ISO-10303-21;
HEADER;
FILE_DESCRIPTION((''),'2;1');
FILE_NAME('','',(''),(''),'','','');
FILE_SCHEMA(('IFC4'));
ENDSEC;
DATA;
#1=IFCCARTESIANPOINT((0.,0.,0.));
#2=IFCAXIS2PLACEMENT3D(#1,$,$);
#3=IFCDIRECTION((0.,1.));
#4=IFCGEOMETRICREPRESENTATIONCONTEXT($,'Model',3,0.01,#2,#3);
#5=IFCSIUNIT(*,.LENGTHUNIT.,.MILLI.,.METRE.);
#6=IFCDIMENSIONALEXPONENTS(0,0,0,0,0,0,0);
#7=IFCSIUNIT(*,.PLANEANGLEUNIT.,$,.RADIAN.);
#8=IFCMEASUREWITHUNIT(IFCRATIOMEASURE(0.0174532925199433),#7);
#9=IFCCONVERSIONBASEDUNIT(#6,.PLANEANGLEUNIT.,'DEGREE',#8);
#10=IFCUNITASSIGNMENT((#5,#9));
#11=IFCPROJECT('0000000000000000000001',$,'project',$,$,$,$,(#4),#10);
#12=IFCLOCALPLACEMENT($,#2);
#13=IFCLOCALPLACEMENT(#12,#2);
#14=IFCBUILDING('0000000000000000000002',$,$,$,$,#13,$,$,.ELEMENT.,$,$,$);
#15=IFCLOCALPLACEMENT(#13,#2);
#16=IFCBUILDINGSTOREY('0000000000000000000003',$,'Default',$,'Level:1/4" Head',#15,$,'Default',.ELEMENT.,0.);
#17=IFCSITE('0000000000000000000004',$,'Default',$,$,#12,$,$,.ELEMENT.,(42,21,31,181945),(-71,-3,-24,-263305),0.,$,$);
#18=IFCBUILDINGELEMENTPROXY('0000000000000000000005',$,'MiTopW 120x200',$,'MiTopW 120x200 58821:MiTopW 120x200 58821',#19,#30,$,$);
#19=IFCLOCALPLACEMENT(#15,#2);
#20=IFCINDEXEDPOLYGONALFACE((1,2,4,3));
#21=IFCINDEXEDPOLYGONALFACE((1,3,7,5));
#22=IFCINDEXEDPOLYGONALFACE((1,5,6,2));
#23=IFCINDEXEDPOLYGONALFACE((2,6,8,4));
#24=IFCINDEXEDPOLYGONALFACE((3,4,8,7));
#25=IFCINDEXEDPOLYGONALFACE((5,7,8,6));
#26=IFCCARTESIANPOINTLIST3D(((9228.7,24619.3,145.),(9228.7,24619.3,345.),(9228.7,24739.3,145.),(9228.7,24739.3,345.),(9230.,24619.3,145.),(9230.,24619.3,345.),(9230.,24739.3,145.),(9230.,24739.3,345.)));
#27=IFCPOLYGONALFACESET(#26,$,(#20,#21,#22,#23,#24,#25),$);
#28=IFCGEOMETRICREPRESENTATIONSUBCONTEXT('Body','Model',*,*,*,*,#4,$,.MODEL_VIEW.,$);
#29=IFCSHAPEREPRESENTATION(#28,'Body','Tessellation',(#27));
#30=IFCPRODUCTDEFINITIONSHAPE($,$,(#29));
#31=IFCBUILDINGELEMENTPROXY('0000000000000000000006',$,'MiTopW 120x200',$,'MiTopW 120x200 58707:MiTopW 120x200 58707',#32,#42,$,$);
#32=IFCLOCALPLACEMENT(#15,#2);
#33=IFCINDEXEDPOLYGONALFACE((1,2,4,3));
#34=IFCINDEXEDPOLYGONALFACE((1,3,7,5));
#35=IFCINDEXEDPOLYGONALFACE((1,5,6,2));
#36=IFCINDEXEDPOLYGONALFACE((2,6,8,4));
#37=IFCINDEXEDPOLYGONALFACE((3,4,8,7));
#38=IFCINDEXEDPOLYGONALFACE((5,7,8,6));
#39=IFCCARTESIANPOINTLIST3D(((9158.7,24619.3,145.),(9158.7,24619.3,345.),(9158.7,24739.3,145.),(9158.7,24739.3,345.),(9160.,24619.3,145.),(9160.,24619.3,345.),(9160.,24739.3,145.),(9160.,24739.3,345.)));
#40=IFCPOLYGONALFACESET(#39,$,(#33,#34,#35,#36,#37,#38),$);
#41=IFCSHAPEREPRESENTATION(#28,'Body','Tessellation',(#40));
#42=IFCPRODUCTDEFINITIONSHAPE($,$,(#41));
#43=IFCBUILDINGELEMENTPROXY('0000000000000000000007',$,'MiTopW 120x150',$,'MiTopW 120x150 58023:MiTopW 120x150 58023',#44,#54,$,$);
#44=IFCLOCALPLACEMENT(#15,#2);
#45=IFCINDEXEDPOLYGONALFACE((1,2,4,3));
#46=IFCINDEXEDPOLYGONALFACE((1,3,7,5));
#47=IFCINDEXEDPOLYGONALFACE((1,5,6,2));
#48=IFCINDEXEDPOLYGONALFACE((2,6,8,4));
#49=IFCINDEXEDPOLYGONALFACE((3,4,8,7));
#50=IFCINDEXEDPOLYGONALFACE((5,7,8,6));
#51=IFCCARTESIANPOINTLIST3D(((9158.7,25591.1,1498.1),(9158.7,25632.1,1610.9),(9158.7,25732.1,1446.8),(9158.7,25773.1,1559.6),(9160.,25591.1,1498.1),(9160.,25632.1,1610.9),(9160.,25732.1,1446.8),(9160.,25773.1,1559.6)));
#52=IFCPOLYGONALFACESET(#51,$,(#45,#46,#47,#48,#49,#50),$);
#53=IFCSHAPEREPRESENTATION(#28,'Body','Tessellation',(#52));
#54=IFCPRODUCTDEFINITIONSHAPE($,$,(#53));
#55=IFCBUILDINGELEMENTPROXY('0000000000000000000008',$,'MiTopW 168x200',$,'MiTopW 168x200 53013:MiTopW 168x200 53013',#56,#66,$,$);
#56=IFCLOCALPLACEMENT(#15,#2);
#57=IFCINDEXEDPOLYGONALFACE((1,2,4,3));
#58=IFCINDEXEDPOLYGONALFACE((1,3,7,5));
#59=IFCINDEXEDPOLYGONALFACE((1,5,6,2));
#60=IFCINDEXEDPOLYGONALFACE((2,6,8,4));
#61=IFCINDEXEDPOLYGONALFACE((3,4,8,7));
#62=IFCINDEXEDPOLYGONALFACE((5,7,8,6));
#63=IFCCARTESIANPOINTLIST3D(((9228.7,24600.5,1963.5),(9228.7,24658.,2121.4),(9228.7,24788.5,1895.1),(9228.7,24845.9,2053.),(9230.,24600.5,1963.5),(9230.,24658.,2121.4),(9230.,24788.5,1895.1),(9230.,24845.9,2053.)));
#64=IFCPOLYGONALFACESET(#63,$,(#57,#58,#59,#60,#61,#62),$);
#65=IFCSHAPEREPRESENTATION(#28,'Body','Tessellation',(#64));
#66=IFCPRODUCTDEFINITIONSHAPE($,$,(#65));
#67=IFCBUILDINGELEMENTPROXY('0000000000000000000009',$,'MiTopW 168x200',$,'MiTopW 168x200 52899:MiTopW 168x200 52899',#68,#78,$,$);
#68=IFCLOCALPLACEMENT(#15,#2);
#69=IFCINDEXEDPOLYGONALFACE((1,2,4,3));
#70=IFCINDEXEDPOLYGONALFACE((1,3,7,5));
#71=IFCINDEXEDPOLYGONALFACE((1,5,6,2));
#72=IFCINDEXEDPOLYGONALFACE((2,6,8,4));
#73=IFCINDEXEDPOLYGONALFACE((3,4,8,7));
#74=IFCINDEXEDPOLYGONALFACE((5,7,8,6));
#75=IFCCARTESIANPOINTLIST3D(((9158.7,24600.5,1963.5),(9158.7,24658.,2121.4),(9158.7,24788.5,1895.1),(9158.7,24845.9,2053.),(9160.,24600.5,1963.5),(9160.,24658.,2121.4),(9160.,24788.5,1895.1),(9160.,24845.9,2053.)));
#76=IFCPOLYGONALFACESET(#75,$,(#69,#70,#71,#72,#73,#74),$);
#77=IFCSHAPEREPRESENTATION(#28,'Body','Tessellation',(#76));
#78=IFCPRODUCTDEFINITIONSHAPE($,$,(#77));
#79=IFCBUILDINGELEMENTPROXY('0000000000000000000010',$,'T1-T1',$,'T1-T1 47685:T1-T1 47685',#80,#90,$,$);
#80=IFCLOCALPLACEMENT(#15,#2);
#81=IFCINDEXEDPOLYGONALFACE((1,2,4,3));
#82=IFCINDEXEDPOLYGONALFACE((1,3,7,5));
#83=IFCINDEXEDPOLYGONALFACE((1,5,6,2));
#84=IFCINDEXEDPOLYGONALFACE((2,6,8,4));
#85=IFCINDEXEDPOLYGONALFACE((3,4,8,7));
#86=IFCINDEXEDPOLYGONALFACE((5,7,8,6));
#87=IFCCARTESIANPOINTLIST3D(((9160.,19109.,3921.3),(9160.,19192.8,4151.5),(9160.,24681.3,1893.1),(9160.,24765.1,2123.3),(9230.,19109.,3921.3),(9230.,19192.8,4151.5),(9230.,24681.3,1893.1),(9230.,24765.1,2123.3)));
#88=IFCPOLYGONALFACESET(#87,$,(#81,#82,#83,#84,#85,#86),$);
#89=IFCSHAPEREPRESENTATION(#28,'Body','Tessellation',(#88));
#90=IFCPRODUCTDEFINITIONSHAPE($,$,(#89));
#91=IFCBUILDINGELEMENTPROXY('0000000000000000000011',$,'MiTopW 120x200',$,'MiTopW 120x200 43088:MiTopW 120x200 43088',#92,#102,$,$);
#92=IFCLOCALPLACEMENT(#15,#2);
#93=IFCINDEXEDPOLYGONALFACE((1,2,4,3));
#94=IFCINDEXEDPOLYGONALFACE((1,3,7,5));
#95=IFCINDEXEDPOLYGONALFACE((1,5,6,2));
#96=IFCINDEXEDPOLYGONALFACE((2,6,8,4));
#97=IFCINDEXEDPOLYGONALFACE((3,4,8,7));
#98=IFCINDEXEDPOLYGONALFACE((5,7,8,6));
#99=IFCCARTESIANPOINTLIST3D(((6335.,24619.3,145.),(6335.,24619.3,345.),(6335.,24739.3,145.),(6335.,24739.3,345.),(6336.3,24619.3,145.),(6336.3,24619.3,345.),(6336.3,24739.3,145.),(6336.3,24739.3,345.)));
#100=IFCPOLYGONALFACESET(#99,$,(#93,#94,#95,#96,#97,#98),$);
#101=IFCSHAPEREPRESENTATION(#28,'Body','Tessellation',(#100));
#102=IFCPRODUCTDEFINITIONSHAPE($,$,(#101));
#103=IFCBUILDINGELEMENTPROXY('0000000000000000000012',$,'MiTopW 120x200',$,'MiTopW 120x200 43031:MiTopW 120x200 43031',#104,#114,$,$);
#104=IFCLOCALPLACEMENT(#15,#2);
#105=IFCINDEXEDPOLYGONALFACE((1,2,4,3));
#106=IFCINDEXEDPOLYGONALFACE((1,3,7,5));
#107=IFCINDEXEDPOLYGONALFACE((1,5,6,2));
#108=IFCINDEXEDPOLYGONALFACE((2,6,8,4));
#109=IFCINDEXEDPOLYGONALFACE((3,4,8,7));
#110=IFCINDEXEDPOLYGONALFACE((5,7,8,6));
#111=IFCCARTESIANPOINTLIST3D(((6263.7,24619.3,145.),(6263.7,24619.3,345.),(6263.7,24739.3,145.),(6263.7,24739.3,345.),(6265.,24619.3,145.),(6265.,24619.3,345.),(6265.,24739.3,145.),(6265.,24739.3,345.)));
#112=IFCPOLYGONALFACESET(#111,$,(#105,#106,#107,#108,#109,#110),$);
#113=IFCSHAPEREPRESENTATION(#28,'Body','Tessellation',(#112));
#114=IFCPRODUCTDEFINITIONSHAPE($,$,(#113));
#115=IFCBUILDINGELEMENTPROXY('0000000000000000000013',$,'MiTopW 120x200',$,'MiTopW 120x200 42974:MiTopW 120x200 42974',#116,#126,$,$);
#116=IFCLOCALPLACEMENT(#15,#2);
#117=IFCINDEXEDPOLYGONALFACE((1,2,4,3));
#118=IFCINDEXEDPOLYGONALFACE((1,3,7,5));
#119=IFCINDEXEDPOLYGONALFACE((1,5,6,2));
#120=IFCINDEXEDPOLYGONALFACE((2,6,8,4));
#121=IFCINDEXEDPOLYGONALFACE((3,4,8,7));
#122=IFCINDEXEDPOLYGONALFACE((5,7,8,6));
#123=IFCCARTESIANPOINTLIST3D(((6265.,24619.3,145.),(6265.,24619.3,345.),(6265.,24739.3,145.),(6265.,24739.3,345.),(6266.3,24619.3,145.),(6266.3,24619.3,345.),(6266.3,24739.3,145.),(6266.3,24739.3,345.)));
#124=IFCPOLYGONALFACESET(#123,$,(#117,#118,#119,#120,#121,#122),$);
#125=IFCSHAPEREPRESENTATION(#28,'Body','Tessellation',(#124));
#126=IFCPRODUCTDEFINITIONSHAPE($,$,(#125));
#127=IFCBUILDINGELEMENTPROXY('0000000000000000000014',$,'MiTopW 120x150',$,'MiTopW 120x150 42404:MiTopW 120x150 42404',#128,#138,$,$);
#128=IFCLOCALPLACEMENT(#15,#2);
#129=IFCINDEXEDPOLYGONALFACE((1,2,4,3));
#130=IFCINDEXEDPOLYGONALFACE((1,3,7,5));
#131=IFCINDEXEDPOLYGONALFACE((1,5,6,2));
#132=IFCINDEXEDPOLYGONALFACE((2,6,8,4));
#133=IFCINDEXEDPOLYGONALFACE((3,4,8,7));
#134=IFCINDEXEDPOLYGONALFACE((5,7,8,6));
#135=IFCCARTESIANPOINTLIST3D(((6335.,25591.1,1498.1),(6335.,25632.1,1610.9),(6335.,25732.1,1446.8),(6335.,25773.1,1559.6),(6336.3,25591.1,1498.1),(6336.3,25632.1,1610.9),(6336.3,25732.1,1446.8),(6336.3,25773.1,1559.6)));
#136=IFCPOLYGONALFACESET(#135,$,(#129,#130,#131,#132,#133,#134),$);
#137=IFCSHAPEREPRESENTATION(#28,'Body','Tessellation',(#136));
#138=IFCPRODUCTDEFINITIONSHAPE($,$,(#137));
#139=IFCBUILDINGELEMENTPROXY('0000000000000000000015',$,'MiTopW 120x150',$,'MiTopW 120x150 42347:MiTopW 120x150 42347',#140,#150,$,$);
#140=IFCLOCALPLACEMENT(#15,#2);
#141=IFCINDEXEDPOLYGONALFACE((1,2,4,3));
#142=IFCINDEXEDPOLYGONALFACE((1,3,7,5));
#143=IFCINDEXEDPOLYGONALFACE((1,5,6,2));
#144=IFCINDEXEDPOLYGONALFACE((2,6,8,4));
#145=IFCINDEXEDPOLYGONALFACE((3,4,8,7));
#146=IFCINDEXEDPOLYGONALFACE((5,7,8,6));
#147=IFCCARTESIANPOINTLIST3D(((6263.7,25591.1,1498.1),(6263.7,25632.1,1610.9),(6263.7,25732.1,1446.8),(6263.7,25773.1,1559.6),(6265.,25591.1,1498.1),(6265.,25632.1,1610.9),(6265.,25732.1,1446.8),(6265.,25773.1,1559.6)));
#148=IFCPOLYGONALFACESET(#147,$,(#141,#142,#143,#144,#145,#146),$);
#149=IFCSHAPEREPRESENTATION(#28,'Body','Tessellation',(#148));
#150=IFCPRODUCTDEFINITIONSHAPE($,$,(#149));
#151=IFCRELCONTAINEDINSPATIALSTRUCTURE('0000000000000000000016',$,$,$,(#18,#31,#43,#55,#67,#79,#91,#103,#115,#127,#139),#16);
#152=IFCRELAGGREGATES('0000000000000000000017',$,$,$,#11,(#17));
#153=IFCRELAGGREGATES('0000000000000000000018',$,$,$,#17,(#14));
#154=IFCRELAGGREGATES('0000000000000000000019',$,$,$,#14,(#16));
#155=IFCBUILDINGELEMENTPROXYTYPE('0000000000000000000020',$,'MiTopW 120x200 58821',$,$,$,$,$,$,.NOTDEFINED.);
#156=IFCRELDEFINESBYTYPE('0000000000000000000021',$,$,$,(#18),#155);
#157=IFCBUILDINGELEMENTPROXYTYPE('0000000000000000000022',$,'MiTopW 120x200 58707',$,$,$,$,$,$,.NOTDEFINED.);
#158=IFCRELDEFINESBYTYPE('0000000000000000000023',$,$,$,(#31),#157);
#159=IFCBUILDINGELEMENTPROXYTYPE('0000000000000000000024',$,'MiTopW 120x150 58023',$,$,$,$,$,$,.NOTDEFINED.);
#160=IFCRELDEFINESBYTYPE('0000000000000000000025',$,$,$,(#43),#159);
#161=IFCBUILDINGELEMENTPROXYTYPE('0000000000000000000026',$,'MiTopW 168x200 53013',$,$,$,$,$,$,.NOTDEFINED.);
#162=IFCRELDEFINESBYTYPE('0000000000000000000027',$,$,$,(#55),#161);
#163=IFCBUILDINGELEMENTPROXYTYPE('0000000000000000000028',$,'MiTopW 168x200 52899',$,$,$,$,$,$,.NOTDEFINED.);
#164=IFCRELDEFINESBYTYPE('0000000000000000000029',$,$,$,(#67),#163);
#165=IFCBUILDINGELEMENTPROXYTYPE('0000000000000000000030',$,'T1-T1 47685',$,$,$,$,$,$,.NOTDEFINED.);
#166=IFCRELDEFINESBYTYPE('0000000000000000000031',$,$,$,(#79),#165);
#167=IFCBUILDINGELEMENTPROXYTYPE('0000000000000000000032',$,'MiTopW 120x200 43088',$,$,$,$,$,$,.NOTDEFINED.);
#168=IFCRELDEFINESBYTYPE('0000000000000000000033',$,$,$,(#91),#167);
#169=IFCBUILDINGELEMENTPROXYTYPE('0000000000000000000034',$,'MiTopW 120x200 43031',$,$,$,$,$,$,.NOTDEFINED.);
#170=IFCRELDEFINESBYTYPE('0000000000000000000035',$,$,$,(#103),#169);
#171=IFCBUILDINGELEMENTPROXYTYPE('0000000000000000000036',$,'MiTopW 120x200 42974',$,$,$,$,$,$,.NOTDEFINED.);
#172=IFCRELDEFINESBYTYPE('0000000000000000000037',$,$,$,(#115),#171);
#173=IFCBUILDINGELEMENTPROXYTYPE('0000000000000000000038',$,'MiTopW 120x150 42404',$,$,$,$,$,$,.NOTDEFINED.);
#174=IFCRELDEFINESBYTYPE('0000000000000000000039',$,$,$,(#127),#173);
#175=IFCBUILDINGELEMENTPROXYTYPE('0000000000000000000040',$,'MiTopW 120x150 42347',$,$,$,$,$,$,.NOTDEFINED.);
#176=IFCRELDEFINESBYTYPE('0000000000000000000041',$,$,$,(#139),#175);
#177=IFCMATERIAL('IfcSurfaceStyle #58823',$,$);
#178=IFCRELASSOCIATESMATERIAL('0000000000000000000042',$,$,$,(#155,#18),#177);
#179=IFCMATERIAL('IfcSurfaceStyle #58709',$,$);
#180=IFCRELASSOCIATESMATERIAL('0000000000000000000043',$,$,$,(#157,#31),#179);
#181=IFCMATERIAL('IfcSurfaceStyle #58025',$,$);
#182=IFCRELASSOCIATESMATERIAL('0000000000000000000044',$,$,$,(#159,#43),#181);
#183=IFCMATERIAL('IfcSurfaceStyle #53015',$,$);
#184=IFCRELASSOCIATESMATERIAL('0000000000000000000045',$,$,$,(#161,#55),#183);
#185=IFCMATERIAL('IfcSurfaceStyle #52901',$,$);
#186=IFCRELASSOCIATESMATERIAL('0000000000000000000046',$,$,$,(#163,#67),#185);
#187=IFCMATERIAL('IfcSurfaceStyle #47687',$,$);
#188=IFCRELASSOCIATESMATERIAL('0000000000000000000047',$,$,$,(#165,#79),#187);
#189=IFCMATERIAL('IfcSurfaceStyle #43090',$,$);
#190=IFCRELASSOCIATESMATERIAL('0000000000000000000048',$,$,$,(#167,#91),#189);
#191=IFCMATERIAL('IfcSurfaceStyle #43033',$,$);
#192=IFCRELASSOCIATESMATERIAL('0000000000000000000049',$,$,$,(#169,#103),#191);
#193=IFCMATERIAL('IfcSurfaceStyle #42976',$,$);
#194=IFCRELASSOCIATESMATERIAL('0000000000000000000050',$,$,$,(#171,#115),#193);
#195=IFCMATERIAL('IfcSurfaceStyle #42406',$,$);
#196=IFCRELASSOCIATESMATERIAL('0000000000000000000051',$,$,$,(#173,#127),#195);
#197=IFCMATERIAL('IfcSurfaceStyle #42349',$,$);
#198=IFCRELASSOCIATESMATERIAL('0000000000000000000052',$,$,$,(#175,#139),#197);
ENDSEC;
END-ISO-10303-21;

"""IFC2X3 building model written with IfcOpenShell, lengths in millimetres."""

from ifc_helpers import new_model, entity, si_unit, converted_unit, direction, frame, origin, origin_2d_with_axis, place, context, subcontext, project, spatial, polyline, rectangle, outline, extrude, source, transform, mapped, material, type_object, type_shapes, element, save


model = new_model("IFC2X3")

# Units and contexts
model_context = context("Model", 3, precision=0.01, world=origin(), true_north=direction((0.0, 1.0)))
body_context = subcontext(model_context, "Body", "Model", "MODEL_VIEW")
ifc_project = project(units=[si_unit("LENGTHUNIT", "METRE", prefix="MILLI"), converted_unit("PLANEANGLEUNIT", "DEGREE", entity("IfcRatioMeasure", 0.0174532925199433), si_unit("PLANEANGLEUNIT", "RADIAN"), dimensions=[0, 0, 0, 0, 0, 0, 0])], contexts=[model_context])

# Site, building, storey
site_placement = place(None, origin())
site = spatial("IfcSite", under=ifc_project, at=site_placement, Name="Default", CompositionType="ELEMENT", RefLatitude=(42, 21, 31, 181945), RefLongitude=(-71, -3, -24, -263305), RefElevation=0.0)
building_placement = place(site_placement, origin())
building = spatial("IfcBuilding", under=site, at=building_placement, CompositionType="ELEMENT")
storey_placement = place(building_placement, origin())
storey = spatial("IfcBuildingStorey", under=building, at=storey_placement, Name="Default", ObjectType="Level:1/4\" Head", LongName="Default", CompositionType="ELEMENT", Elevation=0.0)

# Building element proxies
ifc_material_1 = material(Name="IfcSurfaceStyle #58823")
building_element_proxy_type_1 = type_object("IfcBuildingElementProxyType", Name="MiTopW 120x200 58821", PredefinedType="NOTDEFINED", material=ifc_material_1)
shared_shape_1 = source(origin(), body_context, "Body", "SweptSolid", [
    extrude(rectangle(XDim=200.0, YDim=120.0, at=origin_2d_with_axis()), frame((100.0, 60.0, 0.0), z_axis=(0.0, 0.0, 1.0), x_axis=(-1.0, 0.0, 0.0)), (0.0, 0.0, 1.0), 1.3),
])
type_shapes(building_element_proxy_type_1, [shared_shape_1])
proxy_1_placement = place(building_placement, frame((9230.0, 24619.3, 145.0), z_axis=(-1.0, 0.0, 0.0), x_axis=(0.0, 0.0, 1.0)))
element("IfcBuildingElementProxy", 1, at=proxy_1_placement, inside=storey, type_object=building_element_proxy_type_1, material=ifc_material_1, Name="MiTopW 120x200", ObjectType="MiTopW 120x200 58821:MiTopW 120x200 58821", context=body_context, shape_type="MappedRepresentation", body=[
    mapped(shared_shape_1, transform((0.0, 0.0, 0.0), scale=1.0)),
])
ifc_material_2 = material(Name="IfcSurfaceStyle #58709")
building_element_proxy_type_2 = type_object("IfcBuildingElementProxyType", Name="MiTopW 120x200 58707", PredefinedType="NOTDEFINED", material=ifc_material_2)
shared_shape_2 = source(origin(), body_context, "Body", "SweptSolid", [
    extrude(rectangle(XDim=200.0, YDim=120.0, at=origin_2d_with_axis()), frame((100.0, 60.0, 0.0), z_axis=(0.0, 0.0, 1.0), x_axis=(-1.0, 0.0, 0.0)), (0.0, 0.0, 1.0), 1.3),
])
type_shapes(building_element_proxy_type_2, [shared_shape_2])
proxy_2_placement = place(building_placement, frame((9160.0, 24619.3, 145.0), z_axis=(-1.0, 0.0, 0.0), x_axis=(0.0, 0.0, 1.0)))
element("IfcBuildingElementProxy", 2, at=proxy_2_placement, inside=storey, type_object=building_element_proxy_type_2, material=ifc_material_2, Name="MiTopW 120x200", ObjectType="MiTopW 120x200 58707:MiTopW 120x200 58707", context=body_context, shape_type="MappedRepresentation", body=[
    mapped(shared_shape_2, transform((0.0, 0.0, 0.0), scale=1.0)),
])
ifc_material_3 = material(Name="IfcSurfaceStyle #58025")
building_element_proxy_type_3 = type_object("IfcBuildingElementProxyType", Name="MiTopW 120x150 58023", PredefinedType="NOTDEFINED", material=ifc_material_3)
shared_shape_3 = source(origin(), body_context, "Body", "SweptSolid", [
    extrude(outline(polyline([(-75.0, -60.0), (75.0, -60.0), (75.0, 60.0), (-75.0, 60.0), (-75.0, -60.0)])), frame((75.0, 60.0, 0.0), z_axis=(0.0, 0.0, 1.0), x_axis=(-1.0, 0.0, 0.0)), (0.0, 0.0, 1.0), 1.3),
])
type_shapes(building_element_proxy_type_3, [shared_shape_3])
proxy_3_placement = place(building_placement, frame((9160.0, 25732.1, 1446.8), z_axis=(-1.0, 0.0, 0.0), x_axis=(0.0, -0.939693, 0.34202)))
element("IfcBuildingElementProxy", 3, at=proxy_3_placement, inside=storey, type_object=building_element_proxy_type_3, material=ifc_material_3, Name="MiTopW 120x150", ObjectType="MiTopW 120x150 58023:MiTopW 120x150 58023", context=body_context, shape_type="MappedRepresentation", body=[
    mapped(shared_shape_3, transform((0.0, 0.0, 0.0), scale=1.0)),
])
ifc_material_4 = material(Name="IfcSurfaceStyle #53015")
building_element_proxy_type_4 = type_object("IfcBuildingElementProxyType", Name="MiTopW 168x200 53013", PredefinedType="NOTDEFINED", material=ifc_material_4)
shared_shape_4 = source(origin(), body_context, "Body", "SweptSolid", [
    extrude(outline(polyline([(-100.0, -84.0), (100.0, -84.0), (100.0, 84.0), (-100.0, 84.0), (-100.0, -84.0)])), frame((100.0, 84.0, 0.0), z_axis=(0.0, 0.0, 1.0), x_axis=(-1.0, 0.0, 0.0)), (0.0, 0.0, 1.0), 1.3),
])
type_shapes(building_element_proxy_type_4, [shared_shape_4])
proxy_4_placement = place(building_placement, frame((9230.0, 24788.5, 1895.1), z_axis=(-1.0, 0.0, 0.0), x_axis=(0.0, -0.939693, 0.34202)))
element("IfcBuildingElementProxy", 4, at=proxy_4_placement, inside=storey, type_object=building_element_proxy_type_4, material=ifc_material_4, Name="MiTopW 168x200", ObjectType="MiTopW 168x200 53013:MiTopW 168x200 53013", context=body_context, shape_type="MappedRepresentation", body=[
    mapped(shared_shape_4, transform((0.0, 0.0, 0.0), scale=1.0)),
])
ifc_material_5 = material(Name="IfcSurfaceStyle #52901")
building_element_proxy_type_5 = type_object("IfcBuildingElementProxyType", Name="MiTopW 168x200 52899", PredefinedType="NOTDEFINED", material=ifc_material_5)
shared_shape_5 = source(origin(), body_context, "Body", "SweptSolid", [
    extrude(outline(polyline([(-100.0, -84.0), (100.0, -84.0), (100.0, 84.0), (-100.0, 84.0), (-100.0, -84.0)])), frame((100.0, 84.0, 0.0), z_axis=(0.0, 0.0, 1.0), x_axis=(-1.0, 0.0, 0.0)), (0.0, 0.0, 1.0), 1.3),
])
type_shapes(building_element_proxy_type_5, [shared_shape_5])
proxy_5_placement = place(building_placement, frame((9160.0, 24788.5, 1895.1), z_axis=(-1.0, 0.0, 0.0), x_axis=(0.0, -0.939693, 0.34202)))
element("IfcBuildingElementProxy", 5, at=proxy_5_placement, inside=storey, type_object=building_element_proxy_type_5, material=ifc_material_5, Name="MiTopW 168x200", ObjectType="MiTopW 168x200 52899:MiTopW 168x200 52899", context=body_context, shape_type="MappedRepresentation", body=[
    mapped(shared_shape_5, transform((0.0, 0.0, 0.0), scale=1.0)),
])
ifc_material_6 = material(Name="IfcSurfaceStyle #47687")
building_element_proxy_type_6 = type_object("IfcBuildingElementProxyType", Name="T1-T1 47685", PredefinedType="NOTDEFINED", material=ifc_material_6)
shared_shape_6 = source(origin(), body_context, "Body", "SweptSolid", [
    extrude(outline(polyline([(-2965.0, -122.5), (2965.0, -122.5), (2965.0, 122.5), (-2965.0, 122.5), (-2965.0, -122.5)])), frame((2965.0, 122.5, 0.0), z_axis=(0.0, 0.0, 1.0), x_axis=(-1.0, 0.0, 0.0)), (0.0, 0.0, 1.0), 70.0),
])
type_shapes(building_element_proxy_type_6, [shared_shape_6])
proxy_6_placement = place(building_placement, frame((9230.0, 24681.3, 1893.1), z_axis=(-1.0, 0.0, 0.0), x_axis=(0.0, -0.939693, 0.34202)))
element("IfcBuildingElementProxy", 6, at=proxy_6_placement, inside=storey, type_object=building_element_proxy_type_6, material=ifc_material_6, Name="T1-T1", ObjectType="T1-T1 47685:T1-T1 47685", context=body_context, shape_type="MappedRepresentation", body=[
    mapped(shared_shape_6, transform((0.0, 0.0, 0.0), scale=1.0)),
])
ifc_material_7 = material(Name="IfcSurfaceStyle #43090")
building_element_proxy_type_7 = type_object("IfcBuildingElementProxyType", Name="MiTopW 120x200 43088", PredefinedType="NOTDEFINED", material=ifc_material_7)
shared_shape_7 = source(origin(), body_context, "Body", "SweptSolid", [
    extrude(rectangle(XDim=200.0, YDim=120.0, at=origin_2d_with_axis()), frame((100.0, 60.0, 0.0), z_axis=(0.0, 0.0, 1.0), x_axis=(-1.0, 0.0, 0.0)), (0.0, 0.0, 1.0), 1.3),
])
type_shapes(building_element_proxy_type_7, [shared_shape_7])
proxy_7_placement = place(building_placement, frame((6336.3, 24619.3, 145.0), z_axis=(-1.0, 0.0, 0.0), x_axis=(0.0, 0.0, 1.0)))
element("IfcBuildingElementProxy", 7, at=proxy_7_placement, inside=storey, type_object=building_element_proxy_type_7, material=ifc_material_7, Name="MiTopW 120x200", ObjectType="MiTopW 120x200 43088:MiTopW 120x200 43088", context=body_context, shape_type="MappedRepresentation", body=[
    mapped(shared_shape_7, transform((0.0, 0.0, 0.0), scale=1.0)),
])
ifc_material_8 = material(Name="IfcSurfaceStyle #43033")
building_element_proxy_type_8 = type_object("IfcBuildingElementProxyType", Name="MiTopW 120x200 43031", PredefinedType="NOTDEFINED", material=ifc_material_8)
shared_shape_8 = source(origin(), body_context, "Body", "SweptSolid", [
    extrude(rectangle(XDim=200.0, YDim=120.0, at=origin_2d_with_axis()), frame((100.0, 60.0, 0.0), z_axis=(0.0, 0.0, 1.0), x_axis=(-1.0, 0.0, 0.0)), (0.0, 0.0, 1.0), 1.3),
])
type_shapes(building_element_proxy_type_8, [shared_shape_8])
proxy_8_placement = place(building_placement, frame((6265.0, 24619.3, 145.0), z_axis=(-1.0, 0.0, 0.0), x_axis=(0.0, 0.0, 1.0)))
element("IfcBuildingElementProxy", 8, at=proxy_8_placement, inside=storey, type_object=building_element_proxy_type_8, material=ifc_material_8, Name="MiTopW 120x200", ObjectType="MiTopW 120x200 43031:MiTopW 120x200 43031", context=body_context, shape_type="MappedRepresentation", body=[
    mapped(shared_shape_8, transform((0.0, 0.0, 0.0), scale=1.0)),
])
ifc_material_9 = material(Name="IfcSurfaceStyle #42976")
building_element_proxy_type_9 = type_object("IfcBuildingElementProxyType", Name="MiTopW 120x200 42974", PredefinedType="NOTDEFINED", material=ifc_material_9)
shared_shape_9 = source(origin(), body_context, "Body", "SweptSolid", [
    extrude(rectangle(XDim=200.0, YDim=120.0, at=origin_2d_with_axis()), frame((100.0, 60.0, 0.0), z_axis=(0.0, 0.0, 1.0), x_axis=(-1.0, 0.0, 0.0)), (0.0, 0.0, 1.0), 1.3),
])
type_shapes(building_element_proxy_type_9, [shared_shape_9])
proxy_9_placement = place(building_placement, frame((6266.3, 24619.3, 145.0), z_axis=(-1.0, 0.0, 0.0), x_axis=(0.0, 0.0, 1.0)))
element("IfcBuildingElementProxy", 9, at=proxy_9_placement, inside=storey, type_object=building_element_proxy_type_9, material=ifc_material_9, Name="MiTopW 120x200", ObjectType="MiTopW 120x200 42974:MiTopW 120x200 42974", context=body_context, shape_type="MappedRepresentation", body=[
    mapped(shared_shape_9, transform((0.0, 0.0, 0.0), scale=1.0)),
])
ifc_material_10 = material(Name="IfcSurfaceStyle #42406")
building_element_proxy_type_10 = type_object("IfcBuildingElementProxyType", Name="MiTopW 120x150 42404", PredefinedType="NOTDEFINED", material=ifc_material_10)
shared_shape_10 = source(origin(), body_context, "Body", "SweptSolid", [
    extrude(outline(polyline([(-75.0, -60.0), (75.0, -60.0), (75.0, 60.0), (-75.0, 60.0), (-75.0, -60.0)])), frame((75.0, 60.0, 0.0), z_axis=(0.0, 0.0, 1.0), x_axis=(-1.0, 0.0, 0.0)), (0.0, 0.0, 1.0), 1.3),
])
type_shapes(building_element_proxy_type_10, [shared_shape_10])
proxy_10_placement = place(building_placement, frame((6336.3, 25732.1, 1446.8), z_axis=(-1.0, 0.0, 0.0), x_axis=(0.0, -0.939693, 0.34202)))
element("IfcBuildingElementProxy", 10, at=proxy_10_placement, inside=storey, type_object=building_element_proxy_type_10, material=ifc_material_10, Name="MiTopW 120x150", ObjectType="MiTopW 120x150 42404:MiTopW 120x150 42404", context=body_context, shape_type="MappedRepresentation", body=[
    mapped(shared_shape_10, transform((0.0, 0.0, 0.0), scale=1.0)),
])
ifc_material_11 = material(Name="IfcSurfaceStyle #42349")
building_element_proxy_type_11 = type_object("IfcBuildingElementProxyType", Name="MiTopW 120x150 42347", PredefinedType="NOTDEFINED", material=ifc_material_11)
shared_shape_11 = source(origin(), body_context, "Body", "SweptSolid", [
    extrude(outline(polyline([(-75.0, -60.0), (75.0, -60.0), (75.0, 60.0), (-75.0, 60.0), (-75.0, -60.0)])), frame((75.0, 60.0, 0.0), z_axis=(0.0, 0.0, 1.0), x_axis=(-1.0, 0.0, 0.0)), (0.0, 0.0, 1.0), 1.3),
])
type_shapes(building_element_proxy_type_11, [shared_shape_11])
proxy_11_placement = place(building_placement, frame((6265.0, 25732.1, 1446.8), z_axis=(-1.0, 0.0, 0.0), x_axis=(0.0, -0.939693, 0.34202)))
element("IfcBuildingElementProxy", 11, at=proxy_11_placement, inside=storey, type_object=building_element_proxy_type_11, material=ifc_material_11, Name="MiTopW 120x150", ObjectType="MiTopW 120x150 42347:MiTopW 120x150 42347", context=body_context, shape_type="MappedRepresentation", body=[
    mapped(shared_shape_11, transform((0.0, 0.0, 0.0), scale=1.0)),
])

save(model, "model.ifc")
